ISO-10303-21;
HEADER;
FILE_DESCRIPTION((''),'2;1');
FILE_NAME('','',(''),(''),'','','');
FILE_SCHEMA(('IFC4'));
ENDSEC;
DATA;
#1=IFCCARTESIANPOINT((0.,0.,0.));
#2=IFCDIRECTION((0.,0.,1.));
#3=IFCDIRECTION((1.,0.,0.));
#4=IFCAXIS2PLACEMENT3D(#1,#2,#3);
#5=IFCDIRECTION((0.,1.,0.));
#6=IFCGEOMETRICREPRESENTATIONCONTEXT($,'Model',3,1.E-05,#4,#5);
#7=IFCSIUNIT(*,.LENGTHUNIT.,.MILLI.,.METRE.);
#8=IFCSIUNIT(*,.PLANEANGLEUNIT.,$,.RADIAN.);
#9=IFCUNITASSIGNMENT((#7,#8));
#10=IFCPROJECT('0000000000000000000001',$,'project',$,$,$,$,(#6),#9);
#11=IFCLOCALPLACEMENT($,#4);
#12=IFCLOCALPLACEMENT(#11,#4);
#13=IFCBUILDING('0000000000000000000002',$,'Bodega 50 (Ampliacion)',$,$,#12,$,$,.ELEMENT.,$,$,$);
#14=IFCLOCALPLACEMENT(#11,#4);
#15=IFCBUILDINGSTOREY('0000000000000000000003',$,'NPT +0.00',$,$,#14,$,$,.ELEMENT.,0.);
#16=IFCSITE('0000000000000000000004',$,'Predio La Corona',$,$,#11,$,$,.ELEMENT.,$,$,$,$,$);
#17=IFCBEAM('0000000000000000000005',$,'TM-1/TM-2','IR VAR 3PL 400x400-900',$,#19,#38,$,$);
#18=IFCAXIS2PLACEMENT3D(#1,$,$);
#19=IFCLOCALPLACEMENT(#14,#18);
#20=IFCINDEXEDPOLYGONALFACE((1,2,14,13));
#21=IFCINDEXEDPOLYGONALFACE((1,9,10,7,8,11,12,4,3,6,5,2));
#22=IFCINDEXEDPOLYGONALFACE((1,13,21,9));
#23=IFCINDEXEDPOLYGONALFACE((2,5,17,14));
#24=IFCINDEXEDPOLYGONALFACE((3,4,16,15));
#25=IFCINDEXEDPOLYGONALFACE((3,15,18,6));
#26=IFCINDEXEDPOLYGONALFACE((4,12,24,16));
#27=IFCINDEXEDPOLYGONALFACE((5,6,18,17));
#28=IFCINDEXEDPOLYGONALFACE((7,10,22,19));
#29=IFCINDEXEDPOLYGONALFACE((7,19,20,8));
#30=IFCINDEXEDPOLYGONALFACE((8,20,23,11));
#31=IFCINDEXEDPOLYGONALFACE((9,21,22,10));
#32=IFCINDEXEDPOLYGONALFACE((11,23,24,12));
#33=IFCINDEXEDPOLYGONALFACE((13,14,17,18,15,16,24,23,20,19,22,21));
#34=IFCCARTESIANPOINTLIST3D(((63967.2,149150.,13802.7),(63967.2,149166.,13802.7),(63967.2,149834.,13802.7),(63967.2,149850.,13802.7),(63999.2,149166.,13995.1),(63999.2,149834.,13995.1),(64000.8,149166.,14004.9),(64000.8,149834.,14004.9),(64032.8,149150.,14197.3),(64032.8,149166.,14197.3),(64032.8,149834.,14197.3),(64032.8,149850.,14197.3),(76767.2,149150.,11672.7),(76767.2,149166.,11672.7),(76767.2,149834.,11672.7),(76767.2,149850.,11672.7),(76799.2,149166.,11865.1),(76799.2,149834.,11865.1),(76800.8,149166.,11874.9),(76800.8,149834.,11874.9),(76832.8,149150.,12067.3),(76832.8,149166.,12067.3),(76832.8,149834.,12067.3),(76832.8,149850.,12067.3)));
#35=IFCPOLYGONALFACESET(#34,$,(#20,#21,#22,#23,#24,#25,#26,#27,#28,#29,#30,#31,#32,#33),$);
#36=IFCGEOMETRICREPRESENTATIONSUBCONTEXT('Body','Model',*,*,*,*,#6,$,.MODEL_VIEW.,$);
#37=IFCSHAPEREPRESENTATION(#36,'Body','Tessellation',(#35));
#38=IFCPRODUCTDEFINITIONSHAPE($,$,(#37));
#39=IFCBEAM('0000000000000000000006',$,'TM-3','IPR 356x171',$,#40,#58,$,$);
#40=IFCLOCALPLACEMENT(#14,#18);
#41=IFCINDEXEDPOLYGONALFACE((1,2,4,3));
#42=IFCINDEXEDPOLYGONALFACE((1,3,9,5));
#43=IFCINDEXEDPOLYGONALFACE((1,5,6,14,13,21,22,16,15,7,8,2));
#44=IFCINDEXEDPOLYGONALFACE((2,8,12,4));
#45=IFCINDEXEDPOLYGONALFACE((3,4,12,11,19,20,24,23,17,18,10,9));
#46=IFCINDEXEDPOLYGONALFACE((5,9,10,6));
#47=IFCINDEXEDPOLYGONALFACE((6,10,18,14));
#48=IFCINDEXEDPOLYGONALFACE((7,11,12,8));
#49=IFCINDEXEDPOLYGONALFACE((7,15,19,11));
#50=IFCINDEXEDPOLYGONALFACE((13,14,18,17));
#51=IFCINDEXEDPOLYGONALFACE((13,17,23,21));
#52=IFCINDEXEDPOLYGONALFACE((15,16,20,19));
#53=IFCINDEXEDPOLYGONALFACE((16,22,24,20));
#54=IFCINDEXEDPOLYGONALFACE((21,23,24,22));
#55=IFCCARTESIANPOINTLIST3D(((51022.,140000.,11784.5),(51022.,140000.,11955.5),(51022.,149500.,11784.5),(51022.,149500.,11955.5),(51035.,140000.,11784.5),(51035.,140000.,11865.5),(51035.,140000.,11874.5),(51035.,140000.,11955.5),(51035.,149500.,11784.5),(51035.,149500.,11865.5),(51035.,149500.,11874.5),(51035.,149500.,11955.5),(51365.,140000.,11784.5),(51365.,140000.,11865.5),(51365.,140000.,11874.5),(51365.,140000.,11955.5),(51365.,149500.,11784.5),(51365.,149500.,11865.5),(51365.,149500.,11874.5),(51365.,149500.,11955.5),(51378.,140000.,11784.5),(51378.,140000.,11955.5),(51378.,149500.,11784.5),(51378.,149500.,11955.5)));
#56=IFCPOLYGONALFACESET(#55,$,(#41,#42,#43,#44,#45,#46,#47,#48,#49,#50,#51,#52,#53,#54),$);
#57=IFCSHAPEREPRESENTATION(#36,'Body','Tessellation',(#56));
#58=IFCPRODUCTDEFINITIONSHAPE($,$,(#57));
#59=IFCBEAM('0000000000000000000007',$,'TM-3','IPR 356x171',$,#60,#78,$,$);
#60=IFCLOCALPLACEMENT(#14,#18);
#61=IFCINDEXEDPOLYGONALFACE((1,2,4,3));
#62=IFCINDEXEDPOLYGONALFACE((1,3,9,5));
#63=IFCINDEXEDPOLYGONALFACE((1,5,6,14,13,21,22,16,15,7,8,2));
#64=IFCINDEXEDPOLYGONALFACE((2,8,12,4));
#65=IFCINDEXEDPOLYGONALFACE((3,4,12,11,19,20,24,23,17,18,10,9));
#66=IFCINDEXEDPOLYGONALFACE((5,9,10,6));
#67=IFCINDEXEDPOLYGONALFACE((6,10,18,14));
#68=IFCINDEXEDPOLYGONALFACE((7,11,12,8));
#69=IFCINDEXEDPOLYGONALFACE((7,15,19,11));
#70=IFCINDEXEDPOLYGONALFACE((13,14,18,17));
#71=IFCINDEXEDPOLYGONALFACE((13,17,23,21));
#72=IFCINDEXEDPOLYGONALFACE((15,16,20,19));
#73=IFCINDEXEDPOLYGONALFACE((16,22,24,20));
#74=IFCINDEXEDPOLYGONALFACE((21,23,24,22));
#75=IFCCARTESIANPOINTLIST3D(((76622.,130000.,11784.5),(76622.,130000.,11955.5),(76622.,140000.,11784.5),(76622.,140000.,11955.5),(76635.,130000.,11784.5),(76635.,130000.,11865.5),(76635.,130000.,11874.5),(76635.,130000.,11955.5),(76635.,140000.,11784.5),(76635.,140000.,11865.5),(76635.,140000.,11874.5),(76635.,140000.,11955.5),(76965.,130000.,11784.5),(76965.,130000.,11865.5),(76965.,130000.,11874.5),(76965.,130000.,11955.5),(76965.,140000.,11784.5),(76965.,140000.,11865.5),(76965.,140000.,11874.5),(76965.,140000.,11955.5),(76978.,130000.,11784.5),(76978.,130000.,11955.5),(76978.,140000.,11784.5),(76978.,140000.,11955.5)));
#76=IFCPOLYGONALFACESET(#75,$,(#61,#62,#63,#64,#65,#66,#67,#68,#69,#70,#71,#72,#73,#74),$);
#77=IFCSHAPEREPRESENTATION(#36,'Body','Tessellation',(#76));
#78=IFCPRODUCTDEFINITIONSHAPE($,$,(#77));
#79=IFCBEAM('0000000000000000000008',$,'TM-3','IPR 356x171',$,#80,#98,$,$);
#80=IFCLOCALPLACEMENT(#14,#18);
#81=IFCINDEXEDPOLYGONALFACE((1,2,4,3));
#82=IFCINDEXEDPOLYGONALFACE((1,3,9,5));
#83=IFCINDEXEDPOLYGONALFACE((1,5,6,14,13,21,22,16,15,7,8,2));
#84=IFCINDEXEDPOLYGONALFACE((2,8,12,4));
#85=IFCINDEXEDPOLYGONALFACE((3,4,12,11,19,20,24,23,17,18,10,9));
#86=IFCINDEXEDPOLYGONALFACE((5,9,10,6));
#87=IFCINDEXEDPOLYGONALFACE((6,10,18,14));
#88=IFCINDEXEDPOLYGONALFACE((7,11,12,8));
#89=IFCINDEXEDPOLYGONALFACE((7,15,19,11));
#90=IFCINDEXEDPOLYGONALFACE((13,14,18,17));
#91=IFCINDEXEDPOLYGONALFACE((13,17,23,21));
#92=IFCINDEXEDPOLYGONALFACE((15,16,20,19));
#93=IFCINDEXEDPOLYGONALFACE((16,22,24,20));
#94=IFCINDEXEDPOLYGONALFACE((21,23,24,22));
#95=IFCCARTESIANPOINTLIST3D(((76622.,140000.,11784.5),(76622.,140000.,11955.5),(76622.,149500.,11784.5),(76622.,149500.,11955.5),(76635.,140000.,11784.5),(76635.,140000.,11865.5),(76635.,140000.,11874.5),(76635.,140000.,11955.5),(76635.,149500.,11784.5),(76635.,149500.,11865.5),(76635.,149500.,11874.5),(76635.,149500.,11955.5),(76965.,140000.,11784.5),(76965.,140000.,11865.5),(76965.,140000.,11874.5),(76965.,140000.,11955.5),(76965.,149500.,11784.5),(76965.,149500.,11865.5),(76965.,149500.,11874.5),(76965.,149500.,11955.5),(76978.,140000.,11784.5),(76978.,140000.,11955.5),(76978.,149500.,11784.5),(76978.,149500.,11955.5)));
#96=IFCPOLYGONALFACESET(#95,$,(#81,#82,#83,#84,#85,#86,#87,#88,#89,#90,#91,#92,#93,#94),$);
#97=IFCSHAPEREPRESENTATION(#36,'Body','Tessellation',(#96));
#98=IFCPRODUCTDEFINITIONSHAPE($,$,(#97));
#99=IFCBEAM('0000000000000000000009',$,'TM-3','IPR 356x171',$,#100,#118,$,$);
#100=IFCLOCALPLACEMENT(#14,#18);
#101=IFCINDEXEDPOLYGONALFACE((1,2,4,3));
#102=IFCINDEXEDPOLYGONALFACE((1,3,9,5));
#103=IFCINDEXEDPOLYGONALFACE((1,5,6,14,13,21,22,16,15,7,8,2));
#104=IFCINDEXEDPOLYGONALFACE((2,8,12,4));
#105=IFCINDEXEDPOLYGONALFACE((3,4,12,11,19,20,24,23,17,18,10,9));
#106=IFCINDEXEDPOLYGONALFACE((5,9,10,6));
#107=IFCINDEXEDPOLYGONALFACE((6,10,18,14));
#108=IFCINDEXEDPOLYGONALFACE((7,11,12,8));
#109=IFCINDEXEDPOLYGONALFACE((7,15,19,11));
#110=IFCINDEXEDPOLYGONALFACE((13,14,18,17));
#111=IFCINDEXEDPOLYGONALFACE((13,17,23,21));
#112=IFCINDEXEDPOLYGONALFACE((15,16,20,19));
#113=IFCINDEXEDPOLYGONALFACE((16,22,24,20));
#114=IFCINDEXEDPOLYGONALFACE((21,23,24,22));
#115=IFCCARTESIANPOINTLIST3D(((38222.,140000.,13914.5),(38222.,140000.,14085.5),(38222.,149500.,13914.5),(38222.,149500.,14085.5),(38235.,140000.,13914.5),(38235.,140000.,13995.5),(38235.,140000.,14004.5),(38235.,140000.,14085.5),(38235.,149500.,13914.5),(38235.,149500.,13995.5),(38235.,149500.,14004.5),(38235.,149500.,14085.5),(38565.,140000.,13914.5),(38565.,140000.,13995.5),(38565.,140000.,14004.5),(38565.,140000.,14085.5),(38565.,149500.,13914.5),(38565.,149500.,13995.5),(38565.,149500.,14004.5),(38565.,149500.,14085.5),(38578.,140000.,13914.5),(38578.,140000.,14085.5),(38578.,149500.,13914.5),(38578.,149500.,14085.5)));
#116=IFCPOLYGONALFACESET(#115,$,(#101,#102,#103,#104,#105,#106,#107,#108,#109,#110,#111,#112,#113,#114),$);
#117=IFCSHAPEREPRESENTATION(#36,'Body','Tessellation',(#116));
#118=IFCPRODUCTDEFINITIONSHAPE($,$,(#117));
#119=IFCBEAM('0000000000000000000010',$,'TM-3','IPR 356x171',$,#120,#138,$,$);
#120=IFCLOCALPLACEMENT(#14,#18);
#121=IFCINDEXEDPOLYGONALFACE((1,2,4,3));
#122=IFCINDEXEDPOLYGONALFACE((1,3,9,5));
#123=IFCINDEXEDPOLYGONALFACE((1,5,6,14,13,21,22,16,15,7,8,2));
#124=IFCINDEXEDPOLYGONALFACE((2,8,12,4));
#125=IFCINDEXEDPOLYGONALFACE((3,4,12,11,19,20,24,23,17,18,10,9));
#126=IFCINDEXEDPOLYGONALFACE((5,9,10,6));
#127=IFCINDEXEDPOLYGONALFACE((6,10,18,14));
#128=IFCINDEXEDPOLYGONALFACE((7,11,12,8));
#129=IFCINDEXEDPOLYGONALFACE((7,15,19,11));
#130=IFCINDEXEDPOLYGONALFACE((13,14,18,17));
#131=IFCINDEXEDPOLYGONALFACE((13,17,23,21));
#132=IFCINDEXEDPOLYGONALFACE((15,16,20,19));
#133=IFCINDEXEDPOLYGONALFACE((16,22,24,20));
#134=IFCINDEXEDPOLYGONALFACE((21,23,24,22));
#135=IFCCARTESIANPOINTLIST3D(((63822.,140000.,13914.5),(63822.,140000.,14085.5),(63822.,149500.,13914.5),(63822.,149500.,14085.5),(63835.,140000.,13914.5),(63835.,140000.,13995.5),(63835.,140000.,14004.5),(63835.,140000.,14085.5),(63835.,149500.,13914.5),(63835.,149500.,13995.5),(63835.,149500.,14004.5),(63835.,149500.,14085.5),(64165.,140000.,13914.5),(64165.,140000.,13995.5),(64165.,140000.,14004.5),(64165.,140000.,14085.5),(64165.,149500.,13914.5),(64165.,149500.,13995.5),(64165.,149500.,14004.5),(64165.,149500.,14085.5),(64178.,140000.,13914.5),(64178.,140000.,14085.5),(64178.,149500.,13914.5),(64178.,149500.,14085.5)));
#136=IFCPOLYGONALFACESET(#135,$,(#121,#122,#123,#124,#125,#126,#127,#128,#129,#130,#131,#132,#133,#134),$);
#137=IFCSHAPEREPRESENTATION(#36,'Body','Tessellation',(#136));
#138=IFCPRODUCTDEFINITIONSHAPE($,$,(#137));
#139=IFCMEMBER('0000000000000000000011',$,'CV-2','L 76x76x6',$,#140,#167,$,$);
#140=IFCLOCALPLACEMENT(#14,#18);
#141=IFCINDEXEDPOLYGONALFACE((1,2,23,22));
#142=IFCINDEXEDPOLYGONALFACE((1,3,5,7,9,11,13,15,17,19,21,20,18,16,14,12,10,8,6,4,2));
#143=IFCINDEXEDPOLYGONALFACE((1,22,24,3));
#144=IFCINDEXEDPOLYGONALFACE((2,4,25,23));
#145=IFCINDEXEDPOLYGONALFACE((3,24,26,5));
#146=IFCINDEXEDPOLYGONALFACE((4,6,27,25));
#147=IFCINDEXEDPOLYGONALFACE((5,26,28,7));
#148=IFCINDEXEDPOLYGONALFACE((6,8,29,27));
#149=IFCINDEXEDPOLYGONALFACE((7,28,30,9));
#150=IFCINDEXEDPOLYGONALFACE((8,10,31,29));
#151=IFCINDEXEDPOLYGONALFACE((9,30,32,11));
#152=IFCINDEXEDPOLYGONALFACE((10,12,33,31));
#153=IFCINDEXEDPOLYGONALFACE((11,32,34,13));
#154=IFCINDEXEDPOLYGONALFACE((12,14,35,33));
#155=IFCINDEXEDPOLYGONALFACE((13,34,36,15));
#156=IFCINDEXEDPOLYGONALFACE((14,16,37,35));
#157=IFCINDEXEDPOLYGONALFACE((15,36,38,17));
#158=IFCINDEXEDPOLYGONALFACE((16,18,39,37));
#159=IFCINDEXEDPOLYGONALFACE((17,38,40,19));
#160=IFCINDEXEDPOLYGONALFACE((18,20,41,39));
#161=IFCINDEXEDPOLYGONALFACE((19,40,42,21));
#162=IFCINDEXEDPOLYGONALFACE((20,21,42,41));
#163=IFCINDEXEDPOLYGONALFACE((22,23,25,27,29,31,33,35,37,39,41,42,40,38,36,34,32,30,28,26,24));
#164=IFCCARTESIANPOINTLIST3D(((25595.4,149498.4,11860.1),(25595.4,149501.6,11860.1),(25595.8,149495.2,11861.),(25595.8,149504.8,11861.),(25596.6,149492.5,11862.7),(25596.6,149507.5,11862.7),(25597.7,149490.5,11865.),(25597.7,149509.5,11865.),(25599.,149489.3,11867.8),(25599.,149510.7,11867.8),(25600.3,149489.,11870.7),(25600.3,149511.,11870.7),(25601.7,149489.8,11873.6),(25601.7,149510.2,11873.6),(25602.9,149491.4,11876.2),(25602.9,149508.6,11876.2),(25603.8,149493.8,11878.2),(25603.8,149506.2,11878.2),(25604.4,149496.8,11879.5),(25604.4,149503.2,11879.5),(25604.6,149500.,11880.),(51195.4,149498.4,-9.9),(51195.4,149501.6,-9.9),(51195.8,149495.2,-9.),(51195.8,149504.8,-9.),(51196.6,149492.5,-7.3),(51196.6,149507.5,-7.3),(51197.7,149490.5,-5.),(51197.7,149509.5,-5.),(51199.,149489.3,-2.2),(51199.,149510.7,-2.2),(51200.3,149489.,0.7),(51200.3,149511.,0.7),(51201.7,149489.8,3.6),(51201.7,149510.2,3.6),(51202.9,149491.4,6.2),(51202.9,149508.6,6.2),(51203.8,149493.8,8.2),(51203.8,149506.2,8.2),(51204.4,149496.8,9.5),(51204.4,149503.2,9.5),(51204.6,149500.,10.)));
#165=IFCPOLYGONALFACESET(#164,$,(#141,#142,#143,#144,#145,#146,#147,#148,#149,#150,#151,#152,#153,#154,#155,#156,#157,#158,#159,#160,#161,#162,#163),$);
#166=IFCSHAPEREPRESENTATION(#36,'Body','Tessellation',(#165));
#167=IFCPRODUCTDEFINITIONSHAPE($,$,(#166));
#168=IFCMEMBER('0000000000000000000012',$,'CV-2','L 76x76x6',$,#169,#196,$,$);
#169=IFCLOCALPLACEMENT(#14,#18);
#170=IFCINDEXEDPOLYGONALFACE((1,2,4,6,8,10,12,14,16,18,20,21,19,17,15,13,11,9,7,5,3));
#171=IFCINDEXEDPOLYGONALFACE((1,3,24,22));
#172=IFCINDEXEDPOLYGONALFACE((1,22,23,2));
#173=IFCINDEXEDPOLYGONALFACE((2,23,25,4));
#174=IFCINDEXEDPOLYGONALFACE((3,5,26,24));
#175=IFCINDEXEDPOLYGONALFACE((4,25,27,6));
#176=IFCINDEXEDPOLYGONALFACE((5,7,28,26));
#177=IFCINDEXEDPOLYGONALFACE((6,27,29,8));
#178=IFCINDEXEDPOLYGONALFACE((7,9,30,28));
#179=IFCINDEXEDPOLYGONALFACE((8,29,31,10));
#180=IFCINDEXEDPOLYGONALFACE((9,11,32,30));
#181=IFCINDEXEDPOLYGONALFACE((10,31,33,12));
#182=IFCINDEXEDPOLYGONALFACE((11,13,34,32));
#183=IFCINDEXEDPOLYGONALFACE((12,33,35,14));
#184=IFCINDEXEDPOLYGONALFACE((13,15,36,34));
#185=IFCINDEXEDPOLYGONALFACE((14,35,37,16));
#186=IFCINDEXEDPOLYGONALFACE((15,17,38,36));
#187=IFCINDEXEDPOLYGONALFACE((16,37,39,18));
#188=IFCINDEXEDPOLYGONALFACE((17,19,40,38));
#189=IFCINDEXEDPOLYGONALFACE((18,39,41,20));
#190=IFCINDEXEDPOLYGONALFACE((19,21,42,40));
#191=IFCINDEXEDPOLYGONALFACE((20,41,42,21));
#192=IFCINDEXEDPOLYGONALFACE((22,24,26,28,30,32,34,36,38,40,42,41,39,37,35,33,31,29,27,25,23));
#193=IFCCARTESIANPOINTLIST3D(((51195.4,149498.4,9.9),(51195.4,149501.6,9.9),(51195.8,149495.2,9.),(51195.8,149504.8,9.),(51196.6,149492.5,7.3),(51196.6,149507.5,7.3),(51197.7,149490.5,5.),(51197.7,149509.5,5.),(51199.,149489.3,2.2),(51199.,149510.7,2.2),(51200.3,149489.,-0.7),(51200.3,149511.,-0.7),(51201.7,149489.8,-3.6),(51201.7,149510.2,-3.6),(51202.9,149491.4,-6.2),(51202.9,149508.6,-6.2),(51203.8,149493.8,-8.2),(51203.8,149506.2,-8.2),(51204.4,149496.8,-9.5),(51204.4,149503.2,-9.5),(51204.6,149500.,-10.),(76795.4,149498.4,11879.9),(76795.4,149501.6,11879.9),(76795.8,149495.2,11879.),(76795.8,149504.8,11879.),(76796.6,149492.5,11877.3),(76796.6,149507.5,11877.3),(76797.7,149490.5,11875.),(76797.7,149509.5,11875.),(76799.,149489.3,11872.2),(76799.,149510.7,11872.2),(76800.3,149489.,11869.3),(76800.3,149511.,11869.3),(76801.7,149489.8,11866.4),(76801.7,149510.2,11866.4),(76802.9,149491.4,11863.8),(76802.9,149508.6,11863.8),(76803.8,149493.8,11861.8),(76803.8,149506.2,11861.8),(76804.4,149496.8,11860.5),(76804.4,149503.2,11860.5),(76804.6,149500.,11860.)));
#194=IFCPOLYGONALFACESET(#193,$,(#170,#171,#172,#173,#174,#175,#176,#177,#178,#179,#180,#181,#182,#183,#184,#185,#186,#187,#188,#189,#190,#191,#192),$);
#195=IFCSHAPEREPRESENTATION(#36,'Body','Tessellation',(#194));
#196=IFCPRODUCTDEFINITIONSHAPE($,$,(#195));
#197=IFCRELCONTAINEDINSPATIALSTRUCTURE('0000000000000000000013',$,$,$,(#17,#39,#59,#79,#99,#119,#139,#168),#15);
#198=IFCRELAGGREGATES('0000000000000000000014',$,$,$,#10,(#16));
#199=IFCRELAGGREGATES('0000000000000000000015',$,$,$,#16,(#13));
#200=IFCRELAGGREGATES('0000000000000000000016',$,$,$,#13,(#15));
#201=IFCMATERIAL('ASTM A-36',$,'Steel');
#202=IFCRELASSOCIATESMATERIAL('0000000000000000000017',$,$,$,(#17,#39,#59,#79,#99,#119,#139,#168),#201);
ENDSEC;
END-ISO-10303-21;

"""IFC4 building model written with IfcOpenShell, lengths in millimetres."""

from ifc_helpers import new_model, si_unit, direction, frame, origin_with_axes, origin_2d, place, context, subcontext, project, spatial, circle, i_section, extrude, material, element, save


model = new_model("IFC4")

# Units and contexts
model_context = context("Model", 3, precision=1e-05, world=origin_with_axes(), true_north=direction((0.0, 1.0, 0.0)))
body_context = subcontext(model_context, "Body", "Model", "MODEL_VIEW")
ifc_project = project(units=[si_unit("LENGTHUNIT", "METRE", prefix="MILLI"), si_unit("PLANEANGLEUNIT", "RADIAN")], contexts=[model_context])

# Site, building, storey
site_placement = place(None, origin_with_axes())
site = spatial("IfcSite", under=ifc_project, at=site_placement, Name="Predio La Corona", CompositionType="ELEMENT")
building_placement = place(site_placement, origin_with_axes())
building = spatial("IfcBuilding", under=site, at=building_placement, Name="Bodega 50 (Ampliacion)", CompositionType="ELEMENT")
storey_placement = place(site_placement, origin_with_axes())
storey = spatial("IfcBuildingStorey", under=building, at=storey_placement, Name="NPT +0.00", CompositionType="ELEMENT", Elevation=0.0)

# Shared definitions
ifc_material = material(Name="ASTM A-36", Category="Steel")

# Beams
for number, where, z_axis, x_axis, name in (
    (1, (64000.0, 149500.0, 14000.0), (0.986436, 0.0, -0.164149), (-0.164149, 0.0, -0.986436), "TM-1/TM-2"),
):
    element("IfcBeam", number, at=place(storey_placement, frame(where, z_axis=z_axis, x_axis=x_axis)), inside=storey, material=ifc_material, Name=name, Description="IR VAR 3PL 400x400-900", context=body_context, shape_type="SweptSolid", body=[
        extrude(i_section(OverallWidth=400.0, OverallDepth=700.0, WebThickness=10.0, FlangeThickness=16.0, at=origin_2d()), origin_with_axes(), (0.0, 0.0, 1.0), 12976.0),
    ])
beam_1_placement = place(storey_placement, frame((51200.0, 140000.0, 11870.0), z_axis=(0.0, 1.0, 0.0), x_axis=(0.0, 0.0, 1.0)))
element("IfcBeam", 2, at=beam_1_placement, inside=storey, material=ifc_material, Name="TM-3", Description="IPR 356x171", context=body_context, shape_type="SweptSolid", body=[
    extrude(i_section(OverallWidth=171.0, OverallDepth=356.0, WebThickness=9.0, FlangeThickness=13.0, at=origin_2d()), origin_with_axes(), (0.0, 0.0, 1.0), 9500.0),
])
beam_2_placement = place(storey_placement, frame((76800.0, 130000.0, 11870.0), z_axis=(0.0, 1.0, 0.0), x_axis=(0.0, 0.0, 1.0)))
element("IfcBeam", 3, at=beam_2_placement, inside=storey, material=ifc_material, Name="TM-3", Description="IPR 356x171", context=body_context, shape_type="SweptSolid", body=[
    extrude(i_section(OverallWidth=171.0, OverallDepth=356.0, WebThickness=9.0, FlangeThickness=13.0, at=origin_2d()), origin_with_axes(), (0.0, 0.0, 1.0), 10000.0),
])
for number, where, z_axis, x_axis, name in (
    (4, (76800.0, 140000.0, 11870.0), (0.0, 1.0, 0.0), (0.0, 0.0, 1.0), "TM-3"),
    (5, (38400.0, 140000.0, 14000.0), (0.0, 1.0, 0.0), (0.0, 0.0, 1.0), "TM-3"),
    (6, (64000.0, 140000.0, 14000.0), (0.0, 1.0, 0.0), (0.0, 0.0, 1.0), "TM-3"),
):
    element("IfcBeam", number, at=place(storey_placement, frame(where, z_axis=z_axis, x_axis=x_axis)), inside=storey, material=ifc_material, Name=name, Description="IPR 356x171", context=body_context, shape_type="SweptSolid", body=[
        extrude(i_section(OverallWidth=171.0, OverallDepth=356.0, WebThickness=9.0, FlangeThickness=13.0, at=origin_2d()), origin_with_axes(), (0.0, 0.0, 1.0), 9500.0),
    ])

# Members
for number, where, z_axis, x_axis, name in (
    (7, (51200.0, 149500.0, 0.0), (-0.907222, 0.0, 0.420653), (0.420653, 0.0, 0.907222), "CV-2"),
    (8, (51200.0, 149500.0, 0.0), (0.907222, 0.0, 0.420653), (0.420653, 0.0, -0.907222), "CV-2"),
):
    element("IfcMember", number, at=place(storey_placement, frame(where, z_axis=z_axis, x_axis=x_axis)), inside=storey, material=ifc_material, Name=name, Description="L 76x76x6", context=body_context, shape_type="SweptSolid", body=[
        extrude(circle(Radius=11.0, at=origin_2d()), origin_with_axes(), (0.0, 0.0, 1.0), 28218.0),
    ])

save(model, "model.ifc")
